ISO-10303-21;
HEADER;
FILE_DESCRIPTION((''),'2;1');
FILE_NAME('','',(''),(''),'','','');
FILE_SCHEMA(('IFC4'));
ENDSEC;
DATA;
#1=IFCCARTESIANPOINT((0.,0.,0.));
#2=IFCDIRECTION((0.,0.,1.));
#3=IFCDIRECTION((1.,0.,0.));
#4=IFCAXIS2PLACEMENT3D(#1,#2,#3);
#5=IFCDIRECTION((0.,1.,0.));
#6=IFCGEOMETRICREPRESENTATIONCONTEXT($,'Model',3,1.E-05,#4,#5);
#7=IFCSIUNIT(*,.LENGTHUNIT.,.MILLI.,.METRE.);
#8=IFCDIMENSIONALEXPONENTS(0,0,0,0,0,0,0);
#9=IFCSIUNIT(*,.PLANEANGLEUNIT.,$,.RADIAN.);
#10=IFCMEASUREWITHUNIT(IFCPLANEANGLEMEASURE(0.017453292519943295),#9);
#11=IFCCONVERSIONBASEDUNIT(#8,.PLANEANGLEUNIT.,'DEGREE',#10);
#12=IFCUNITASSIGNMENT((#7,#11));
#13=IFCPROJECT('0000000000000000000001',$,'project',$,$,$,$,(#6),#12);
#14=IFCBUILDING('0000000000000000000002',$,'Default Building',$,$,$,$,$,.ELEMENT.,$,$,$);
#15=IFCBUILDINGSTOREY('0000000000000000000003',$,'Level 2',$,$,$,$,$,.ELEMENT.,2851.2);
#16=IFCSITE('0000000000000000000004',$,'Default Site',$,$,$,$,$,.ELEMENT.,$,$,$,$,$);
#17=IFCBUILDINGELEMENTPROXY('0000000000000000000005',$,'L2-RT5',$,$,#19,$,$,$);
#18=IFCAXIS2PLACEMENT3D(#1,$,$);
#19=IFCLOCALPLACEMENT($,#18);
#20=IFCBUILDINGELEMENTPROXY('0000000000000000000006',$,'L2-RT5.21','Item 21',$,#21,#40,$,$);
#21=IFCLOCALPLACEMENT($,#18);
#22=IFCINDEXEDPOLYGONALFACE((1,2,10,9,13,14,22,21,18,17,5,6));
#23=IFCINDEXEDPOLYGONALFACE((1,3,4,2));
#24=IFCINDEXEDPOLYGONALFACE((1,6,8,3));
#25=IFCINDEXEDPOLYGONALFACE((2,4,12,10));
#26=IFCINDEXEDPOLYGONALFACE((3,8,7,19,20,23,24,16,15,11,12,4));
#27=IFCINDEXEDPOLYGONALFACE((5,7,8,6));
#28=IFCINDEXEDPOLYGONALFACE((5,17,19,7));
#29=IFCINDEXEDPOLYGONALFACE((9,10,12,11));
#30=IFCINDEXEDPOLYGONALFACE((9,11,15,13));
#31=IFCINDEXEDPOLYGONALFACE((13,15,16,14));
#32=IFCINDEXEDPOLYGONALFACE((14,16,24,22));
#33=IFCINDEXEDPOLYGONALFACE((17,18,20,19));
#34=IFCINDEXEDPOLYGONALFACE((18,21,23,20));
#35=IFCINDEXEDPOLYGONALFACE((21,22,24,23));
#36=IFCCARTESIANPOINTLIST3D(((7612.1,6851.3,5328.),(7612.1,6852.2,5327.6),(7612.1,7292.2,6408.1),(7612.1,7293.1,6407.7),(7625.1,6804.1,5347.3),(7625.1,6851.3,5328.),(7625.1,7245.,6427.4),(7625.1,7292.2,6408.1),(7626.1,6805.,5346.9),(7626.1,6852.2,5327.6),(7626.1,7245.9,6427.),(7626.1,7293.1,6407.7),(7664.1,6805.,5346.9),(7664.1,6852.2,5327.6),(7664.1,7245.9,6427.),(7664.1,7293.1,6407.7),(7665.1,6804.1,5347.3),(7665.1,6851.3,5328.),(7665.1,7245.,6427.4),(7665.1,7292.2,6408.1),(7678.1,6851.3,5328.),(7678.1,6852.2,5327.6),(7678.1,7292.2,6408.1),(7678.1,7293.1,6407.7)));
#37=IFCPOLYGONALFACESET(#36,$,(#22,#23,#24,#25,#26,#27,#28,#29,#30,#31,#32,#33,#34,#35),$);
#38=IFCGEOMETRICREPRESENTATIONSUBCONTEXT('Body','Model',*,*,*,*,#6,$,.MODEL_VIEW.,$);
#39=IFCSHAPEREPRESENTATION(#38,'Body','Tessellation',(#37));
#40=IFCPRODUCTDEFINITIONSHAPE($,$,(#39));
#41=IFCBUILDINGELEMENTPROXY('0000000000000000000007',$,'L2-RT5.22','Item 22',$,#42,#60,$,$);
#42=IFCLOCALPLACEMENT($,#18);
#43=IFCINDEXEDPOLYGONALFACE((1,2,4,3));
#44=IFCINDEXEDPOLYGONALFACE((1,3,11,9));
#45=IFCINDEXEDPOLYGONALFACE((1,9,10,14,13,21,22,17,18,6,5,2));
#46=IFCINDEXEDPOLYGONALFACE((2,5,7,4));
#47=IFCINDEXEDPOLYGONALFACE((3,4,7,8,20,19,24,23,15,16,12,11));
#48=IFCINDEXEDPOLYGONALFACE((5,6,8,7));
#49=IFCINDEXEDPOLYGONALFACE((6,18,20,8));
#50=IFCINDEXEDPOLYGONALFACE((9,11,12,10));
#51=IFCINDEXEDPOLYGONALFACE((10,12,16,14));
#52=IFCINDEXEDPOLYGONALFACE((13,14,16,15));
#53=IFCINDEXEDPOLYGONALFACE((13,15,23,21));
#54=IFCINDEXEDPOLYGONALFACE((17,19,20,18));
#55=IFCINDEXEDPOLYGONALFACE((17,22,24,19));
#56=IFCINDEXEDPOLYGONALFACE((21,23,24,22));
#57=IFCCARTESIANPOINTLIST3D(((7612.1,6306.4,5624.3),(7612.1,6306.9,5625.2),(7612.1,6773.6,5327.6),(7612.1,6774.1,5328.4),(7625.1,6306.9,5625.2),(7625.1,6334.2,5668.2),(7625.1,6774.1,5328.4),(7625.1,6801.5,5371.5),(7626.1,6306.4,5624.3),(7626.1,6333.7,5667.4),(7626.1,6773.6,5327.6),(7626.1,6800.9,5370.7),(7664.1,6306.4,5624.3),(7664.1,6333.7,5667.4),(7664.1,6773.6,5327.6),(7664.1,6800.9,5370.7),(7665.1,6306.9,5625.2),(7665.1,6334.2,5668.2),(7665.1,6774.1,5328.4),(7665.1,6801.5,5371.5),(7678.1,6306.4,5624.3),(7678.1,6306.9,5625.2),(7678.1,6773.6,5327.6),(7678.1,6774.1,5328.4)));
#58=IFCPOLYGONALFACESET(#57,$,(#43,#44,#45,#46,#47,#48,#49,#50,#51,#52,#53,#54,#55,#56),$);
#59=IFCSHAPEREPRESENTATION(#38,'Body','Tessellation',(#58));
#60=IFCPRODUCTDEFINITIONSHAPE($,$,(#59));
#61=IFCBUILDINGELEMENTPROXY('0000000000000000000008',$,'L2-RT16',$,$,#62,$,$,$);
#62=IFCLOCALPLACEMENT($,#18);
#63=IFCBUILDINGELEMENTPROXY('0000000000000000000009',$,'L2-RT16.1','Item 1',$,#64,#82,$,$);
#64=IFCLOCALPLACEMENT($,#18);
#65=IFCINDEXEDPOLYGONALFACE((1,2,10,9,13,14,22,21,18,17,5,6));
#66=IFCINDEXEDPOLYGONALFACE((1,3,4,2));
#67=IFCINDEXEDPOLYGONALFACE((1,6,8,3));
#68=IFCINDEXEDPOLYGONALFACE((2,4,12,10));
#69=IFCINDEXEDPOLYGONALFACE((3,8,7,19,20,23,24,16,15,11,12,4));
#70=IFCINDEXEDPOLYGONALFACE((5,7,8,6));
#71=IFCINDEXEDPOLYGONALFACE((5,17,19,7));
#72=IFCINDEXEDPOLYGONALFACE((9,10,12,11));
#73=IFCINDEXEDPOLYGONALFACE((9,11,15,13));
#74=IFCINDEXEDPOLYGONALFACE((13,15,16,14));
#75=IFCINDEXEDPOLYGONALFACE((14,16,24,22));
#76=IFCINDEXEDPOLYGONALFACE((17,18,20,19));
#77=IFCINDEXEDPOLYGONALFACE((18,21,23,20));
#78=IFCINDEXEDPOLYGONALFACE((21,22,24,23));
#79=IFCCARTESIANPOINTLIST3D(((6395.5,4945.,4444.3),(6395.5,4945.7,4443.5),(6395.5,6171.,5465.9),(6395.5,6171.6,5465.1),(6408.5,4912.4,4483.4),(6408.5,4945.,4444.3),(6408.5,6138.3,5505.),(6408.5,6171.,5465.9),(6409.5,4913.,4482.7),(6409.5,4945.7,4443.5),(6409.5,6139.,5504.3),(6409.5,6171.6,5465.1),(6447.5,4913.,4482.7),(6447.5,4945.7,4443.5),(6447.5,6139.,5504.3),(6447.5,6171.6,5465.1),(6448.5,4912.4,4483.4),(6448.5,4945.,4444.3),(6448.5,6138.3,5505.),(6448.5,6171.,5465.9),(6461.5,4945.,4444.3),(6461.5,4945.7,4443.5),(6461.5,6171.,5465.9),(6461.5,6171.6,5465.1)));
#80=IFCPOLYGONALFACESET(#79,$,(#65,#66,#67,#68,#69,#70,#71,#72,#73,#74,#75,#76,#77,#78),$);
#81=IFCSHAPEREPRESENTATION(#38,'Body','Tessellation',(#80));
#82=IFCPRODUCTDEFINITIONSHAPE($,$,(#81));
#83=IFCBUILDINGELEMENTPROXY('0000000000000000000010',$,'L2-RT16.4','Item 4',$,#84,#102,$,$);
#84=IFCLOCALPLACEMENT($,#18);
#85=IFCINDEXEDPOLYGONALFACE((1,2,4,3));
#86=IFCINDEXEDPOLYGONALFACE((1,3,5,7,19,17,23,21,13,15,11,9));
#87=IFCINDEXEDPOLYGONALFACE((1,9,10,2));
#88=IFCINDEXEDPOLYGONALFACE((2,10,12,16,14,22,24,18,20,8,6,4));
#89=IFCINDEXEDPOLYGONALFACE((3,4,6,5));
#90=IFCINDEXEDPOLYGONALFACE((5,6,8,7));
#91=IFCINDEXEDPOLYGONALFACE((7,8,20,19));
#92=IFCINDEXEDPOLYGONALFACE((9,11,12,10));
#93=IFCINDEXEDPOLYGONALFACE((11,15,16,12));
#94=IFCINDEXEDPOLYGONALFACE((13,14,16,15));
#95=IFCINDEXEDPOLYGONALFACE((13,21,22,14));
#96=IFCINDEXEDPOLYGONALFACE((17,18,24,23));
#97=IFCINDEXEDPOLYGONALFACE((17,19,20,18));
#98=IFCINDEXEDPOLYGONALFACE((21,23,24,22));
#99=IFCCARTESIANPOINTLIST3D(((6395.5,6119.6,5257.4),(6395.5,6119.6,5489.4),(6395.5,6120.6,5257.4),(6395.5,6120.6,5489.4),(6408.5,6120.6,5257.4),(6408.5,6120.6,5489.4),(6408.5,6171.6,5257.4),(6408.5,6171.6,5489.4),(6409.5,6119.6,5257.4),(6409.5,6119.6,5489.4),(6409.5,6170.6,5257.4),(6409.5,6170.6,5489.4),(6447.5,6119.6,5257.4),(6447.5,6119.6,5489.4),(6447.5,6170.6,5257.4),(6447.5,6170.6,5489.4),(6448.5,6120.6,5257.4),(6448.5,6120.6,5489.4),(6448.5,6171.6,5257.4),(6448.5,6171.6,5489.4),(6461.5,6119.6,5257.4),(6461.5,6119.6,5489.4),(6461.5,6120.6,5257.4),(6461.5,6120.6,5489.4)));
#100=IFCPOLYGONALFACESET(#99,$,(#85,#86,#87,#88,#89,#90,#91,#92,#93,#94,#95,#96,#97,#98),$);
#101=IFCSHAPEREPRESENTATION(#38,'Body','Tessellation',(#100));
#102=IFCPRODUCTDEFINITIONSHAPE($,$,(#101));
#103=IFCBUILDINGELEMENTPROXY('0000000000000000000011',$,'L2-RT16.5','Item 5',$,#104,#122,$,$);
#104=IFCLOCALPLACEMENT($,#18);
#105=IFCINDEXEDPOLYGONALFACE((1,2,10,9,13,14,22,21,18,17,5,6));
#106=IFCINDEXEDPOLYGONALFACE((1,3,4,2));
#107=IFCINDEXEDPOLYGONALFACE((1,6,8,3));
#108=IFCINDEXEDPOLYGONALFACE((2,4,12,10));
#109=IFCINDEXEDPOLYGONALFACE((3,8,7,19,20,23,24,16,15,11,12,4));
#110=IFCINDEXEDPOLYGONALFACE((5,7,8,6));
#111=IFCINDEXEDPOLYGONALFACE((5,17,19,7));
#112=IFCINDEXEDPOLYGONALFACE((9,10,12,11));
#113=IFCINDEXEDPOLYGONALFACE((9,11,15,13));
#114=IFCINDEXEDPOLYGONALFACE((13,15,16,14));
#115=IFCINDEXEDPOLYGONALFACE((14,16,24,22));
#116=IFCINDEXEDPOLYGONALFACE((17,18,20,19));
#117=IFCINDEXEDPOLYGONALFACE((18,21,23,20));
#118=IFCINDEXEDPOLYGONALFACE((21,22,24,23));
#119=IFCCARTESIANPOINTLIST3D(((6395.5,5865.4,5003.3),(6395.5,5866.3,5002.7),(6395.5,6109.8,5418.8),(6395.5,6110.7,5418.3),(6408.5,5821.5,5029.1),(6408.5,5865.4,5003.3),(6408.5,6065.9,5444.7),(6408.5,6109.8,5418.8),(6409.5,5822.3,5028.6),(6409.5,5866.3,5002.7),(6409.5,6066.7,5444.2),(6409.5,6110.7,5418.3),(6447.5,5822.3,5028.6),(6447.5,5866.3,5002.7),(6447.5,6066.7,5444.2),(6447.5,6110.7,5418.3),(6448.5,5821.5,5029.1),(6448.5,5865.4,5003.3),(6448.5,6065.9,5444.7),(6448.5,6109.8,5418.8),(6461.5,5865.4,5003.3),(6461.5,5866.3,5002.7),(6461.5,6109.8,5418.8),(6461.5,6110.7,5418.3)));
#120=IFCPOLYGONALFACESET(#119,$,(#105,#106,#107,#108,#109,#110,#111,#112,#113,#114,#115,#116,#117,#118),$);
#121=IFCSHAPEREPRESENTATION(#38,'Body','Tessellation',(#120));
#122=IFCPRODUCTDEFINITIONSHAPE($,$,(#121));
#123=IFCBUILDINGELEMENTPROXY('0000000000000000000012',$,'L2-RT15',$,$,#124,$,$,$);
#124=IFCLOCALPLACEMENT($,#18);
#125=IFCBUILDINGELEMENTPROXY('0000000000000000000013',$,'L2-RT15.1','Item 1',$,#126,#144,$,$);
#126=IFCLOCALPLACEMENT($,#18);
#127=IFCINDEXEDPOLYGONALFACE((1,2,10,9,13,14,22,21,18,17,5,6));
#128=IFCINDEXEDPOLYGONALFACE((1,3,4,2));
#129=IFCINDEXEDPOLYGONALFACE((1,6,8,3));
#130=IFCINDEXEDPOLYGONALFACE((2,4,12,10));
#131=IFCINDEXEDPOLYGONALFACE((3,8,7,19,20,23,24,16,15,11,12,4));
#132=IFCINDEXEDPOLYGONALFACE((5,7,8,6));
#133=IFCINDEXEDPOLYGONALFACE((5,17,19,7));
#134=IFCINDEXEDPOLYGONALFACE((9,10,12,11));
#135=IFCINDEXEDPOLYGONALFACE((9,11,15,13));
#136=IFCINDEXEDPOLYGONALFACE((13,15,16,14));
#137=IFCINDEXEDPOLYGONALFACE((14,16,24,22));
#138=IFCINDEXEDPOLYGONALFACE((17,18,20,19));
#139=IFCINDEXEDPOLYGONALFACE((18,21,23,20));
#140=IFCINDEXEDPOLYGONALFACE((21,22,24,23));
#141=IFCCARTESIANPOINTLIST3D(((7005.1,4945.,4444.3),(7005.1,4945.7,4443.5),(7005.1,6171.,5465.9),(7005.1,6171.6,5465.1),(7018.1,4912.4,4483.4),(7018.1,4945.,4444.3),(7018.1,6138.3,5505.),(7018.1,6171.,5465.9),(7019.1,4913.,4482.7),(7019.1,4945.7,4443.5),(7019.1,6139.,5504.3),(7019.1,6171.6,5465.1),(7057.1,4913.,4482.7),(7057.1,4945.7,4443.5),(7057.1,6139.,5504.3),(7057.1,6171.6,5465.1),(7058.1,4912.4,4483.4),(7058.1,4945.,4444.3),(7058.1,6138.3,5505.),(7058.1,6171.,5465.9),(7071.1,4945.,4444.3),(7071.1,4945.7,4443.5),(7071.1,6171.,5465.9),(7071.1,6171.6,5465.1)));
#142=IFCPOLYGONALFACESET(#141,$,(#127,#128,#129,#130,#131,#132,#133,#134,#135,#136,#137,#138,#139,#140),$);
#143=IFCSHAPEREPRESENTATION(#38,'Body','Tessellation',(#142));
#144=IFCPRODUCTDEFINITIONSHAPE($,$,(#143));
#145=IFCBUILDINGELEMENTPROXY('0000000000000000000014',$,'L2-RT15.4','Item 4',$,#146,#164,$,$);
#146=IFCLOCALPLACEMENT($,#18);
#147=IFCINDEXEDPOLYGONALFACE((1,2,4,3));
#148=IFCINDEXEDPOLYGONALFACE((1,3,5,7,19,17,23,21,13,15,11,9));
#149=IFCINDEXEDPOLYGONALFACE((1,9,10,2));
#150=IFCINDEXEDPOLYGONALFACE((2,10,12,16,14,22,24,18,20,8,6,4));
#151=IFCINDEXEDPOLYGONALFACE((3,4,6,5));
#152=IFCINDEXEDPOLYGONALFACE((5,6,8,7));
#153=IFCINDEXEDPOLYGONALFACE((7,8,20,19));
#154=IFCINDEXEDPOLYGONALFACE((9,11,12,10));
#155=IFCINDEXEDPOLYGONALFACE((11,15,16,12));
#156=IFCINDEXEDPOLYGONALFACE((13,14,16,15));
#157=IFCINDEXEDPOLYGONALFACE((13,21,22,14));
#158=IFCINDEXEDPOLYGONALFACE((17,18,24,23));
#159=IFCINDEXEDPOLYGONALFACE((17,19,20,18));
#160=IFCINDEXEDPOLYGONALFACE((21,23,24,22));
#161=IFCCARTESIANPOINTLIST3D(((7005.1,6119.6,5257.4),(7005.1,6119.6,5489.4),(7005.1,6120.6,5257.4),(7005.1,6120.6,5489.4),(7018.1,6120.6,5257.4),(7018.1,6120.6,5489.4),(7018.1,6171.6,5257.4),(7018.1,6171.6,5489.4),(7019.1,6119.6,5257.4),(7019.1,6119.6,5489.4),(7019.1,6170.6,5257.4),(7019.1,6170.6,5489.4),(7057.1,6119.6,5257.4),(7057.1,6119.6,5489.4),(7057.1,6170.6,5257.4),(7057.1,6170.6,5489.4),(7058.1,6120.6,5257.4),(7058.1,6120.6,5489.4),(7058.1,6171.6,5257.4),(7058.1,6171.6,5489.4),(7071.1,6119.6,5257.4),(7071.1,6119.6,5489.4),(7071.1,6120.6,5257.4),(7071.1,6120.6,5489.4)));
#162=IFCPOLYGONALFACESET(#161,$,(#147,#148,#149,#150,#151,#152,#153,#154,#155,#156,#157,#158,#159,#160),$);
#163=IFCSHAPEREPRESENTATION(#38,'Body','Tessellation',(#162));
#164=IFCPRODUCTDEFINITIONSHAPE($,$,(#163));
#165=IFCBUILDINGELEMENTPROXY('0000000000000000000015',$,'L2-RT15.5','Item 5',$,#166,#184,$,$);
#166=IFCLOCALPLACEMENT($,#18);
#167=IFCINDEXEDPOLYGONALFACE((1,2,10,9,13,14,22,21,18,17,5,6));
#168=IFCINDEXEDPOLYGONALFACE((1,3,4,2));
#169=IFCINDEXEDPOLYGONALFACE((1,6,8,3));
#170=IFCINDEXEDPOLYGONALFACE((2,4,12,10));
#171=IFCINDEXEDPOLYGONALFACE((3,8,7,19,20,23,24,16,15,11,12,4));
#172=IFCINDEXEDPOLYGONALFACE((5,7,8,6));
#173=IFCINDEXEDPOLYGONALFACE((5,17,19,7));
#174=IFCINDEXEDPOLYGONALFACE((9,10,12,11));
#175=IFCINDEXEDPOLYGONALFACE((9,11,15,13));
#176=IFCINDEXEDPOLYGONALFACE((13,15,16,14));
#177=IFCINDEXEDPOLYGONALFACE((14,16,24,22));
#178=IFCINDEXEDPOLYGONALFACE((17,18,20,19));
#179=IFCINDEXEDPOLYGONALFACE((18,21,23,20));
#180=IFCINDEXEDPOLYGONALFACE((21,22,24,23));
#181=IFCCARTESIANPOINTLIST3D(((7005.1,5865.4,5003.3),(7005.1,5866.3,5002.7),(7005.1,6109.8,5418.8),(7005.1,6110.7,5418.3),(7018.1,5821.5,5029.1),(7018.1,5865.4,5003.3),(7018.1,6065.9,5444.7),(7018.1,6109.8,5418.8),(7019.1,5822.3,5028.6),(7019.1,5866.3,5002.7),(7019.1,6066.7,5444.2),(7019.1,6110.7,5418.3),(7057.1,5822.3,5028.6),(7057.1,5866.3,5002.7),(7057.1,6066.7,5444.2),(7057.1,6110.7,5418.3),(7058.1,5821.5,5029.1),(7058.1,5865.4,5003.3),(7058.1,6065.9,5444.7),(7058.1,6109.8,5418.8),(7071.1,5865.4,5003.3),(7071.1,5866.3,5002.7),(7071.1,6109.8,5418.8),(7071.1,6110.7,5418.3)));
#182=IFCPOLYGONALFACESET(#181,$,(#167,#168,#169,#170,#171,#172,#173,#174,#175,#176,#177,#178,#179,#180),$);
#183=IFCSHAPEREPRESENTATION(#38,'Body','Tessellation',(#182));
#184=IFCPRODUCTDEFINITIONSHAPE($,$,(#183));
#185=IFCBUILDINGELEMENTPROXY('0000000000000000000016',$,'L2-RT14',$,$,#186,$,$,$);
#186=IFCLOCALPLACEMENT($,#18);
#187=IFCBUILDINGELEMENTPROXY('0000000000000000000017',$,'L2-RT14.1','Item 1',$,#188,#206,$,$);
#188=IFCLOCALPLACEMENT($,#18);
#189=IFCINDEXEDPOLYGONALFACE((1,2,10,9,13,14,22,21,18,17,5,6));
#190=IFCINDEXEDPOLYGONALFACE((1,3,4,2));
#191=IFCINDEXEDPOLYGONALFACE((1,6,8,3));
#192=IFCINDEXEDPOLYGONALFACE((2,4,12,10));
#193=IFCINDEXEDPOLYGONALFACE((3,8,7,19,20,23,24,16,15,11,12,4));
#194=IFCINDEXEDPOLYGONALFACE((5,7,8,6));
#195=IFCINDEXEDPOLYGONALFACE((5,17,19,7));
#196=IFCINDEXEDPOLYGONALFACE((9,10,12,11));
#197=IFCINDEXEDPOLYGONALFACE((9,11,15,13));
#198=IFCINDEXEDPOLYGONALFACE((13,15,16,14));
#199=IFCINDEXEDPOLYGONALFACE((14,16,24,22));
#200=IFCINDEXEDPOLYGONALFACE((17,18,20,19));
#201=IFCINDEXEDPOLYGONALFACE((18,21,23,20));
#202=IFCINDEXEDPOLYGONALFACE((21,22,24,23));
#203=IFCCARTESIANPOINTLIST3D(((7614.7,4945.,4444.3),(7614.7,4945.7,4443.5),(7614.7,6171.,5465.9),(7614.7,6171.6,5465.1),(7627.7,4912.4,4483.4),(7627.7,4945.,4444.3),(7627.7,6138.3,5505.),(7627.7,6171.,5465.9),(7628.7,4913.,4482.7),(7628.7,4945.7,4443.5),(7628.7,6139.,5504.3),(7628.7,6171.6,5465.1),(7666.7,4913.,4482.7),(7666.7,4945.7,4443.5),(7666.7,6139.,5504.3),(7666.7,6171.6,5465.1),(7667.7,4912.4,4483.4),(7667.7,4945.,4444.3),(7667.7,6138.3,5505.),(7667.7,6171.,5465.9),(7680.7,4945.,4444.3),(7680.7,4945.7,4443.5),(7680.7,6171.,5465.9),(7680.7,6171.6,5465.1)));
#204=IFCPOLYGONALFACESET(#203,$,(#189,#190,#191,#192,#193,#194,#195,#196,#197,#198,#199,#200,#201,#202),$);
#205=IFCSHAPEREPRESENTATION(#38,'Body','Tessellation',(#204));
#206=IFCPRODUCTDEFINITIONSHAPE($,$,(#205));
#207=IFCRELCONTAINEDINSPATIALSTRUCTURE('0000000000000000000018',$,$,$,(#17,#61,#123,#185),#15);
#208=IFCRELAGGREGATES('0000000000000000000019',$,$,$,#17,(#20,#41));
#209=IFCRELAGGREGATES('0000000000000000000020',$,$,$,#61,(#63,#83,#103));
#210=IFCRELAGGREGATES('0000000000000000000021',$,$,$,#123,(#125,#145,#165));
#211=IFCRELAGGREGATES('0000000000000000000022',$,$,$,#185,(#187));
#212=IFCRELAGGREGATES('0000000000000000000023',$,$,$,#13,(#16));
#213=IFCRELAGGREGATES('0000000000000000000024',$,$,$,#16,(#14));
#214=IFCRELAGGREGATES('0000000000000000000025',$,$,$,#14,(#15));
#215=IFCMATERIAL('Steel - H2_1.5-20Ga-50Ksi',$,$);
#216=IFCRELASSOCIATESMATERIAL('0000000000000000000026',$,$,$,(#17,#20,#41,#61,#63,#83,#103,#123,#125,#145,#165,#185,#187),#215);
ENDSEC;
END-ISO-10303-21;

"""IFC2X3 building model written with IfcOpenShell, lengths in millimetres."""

from ifc_helpers import new_model, entity, si_unit, converted_unit, direction, frame, origin, origin_with_axes, place, context, subcontext, project, spatial, polyline, outline, extrude, material, element, aggregate, save


model = new_model("IFC2X3")

# Units and contexts
model_context = context("Model", 3, precision=1e-05, world=origin_with_axes(), true_north=direction((0.0, 1.0, 0.0)))
body_context = subcontext(model_context, "Body", "Model", "MODEL_VIEW")
ifc_project = project(units=[si_unit("LENGTHUNIT", "METRE", prefix="MILLI"), converted_unit("PLANEANGLEUNIT", "DEGREE", entity("IfcPlaneAngleMeasure", 0.017453292519943295), si_unit("PLANEANGLEUNIT", "RADIAN"), dimensions=[0, 0, 0, 0, 0, 0, 0])], contexts=[model_context])

# Site, building, storey
site = spatial("IfcSite", under=ifc_project, Name="Default Site", CompositionType="ELEMENT")
building = spatial("IfcBuilding", under=site, Name="Default Building", CompositionType="ELEMENT")
storey = spatial("IfcBuildingStorey", under=building, Name="Level 2", CompositionType="ELEMENT", Elevation=2851.2)

# Building element proxies
ifc_material = material(Name="Steel - H2_1.5-20Ga-50Ksi")
proxy_1 = element("IfcBuildingElementProxy", 1, inside=storey, material=ifc_material, Name="L2-RT5")
proxy_2_placement = place(None, frame((7612.1, 7293.1, 6407.7), z_axis=(0.0, -0.378, -0.926), x_axis=(40.0, 0.0, 0.0)))
proxy_2 = element("IfcBuildingElementProxy", 2, at=proxy_2_placement, material=ifc_material, Name="L2-RT5.21", Description="Item 21", context=body_context, shape_type="SweptSolid", body=[
    extrude(outline(polyline([(0.0, 0.0), (14.0, 0.0), (14.0, 51.0), (52.0, 51.0), (52.0, 0.0), (66.0, 0.0), (66.0, 1.0), (53.0, 1.0), (53.0, 52.0), (13.0, 52.0), (13.0, 1.0), (0.0, 1.0), (0.0, 0.0)])), origin(), (0.0, 0.0, 1.0), 1166.6),
])
proxy_3_placement = place(None, frame((7612.1, 6773.6, 5327.6), z_axis=(0.0, -0.844, 0.536), x_axis=(40.0, 0.0, 0.0)))
proxy_3 = element("IfcBuildingElementProxy", 3, at=proxy_3_placement, material=ifc_material, Name="L2-RT5.22", Description="Item 22", context=body_context, shape_type="SweptSolid", body=[
    extrude(outline(polyline([(0.0, 0.0), (14.0, 0.0), (14.0, 51.0), (52.0, 51.0), (52.0, 0.0), (66.0, 0.0), (66.0, 1.0), (53.0, 1.0), (53.0, 52.0), (13.0, 52.0), (13.0, 1.0), (0.0, 1.0), (0.0, 0.0)])), origin(), (0.0, 0.0, 1.0), 553.5),
])
aggregate(proxy_1, [proxy_2, proxy_3])
proxy_4 = element("IfcBuildingElementProxy", 4, inside=storey, material=ifc_material, Name="L2-RT16")
proxy_5_placement = place(None, frame((6395.5, 6171.6, 5465.1), z_axis=(0.0, -0.768, -0.64), x_axis=(40.0, 0.0, 0.0)))
proxy_5 = element("IfcBuildingElementProxy", 5, at=proxy_5_placement, material=ifc_material, Name="L2-RT16.1", Description="Item 1", context=body_context, shape_type="SweptSolid", body=[
    extrude(outline(polyline([(0.0, 0.0), (14.0, 0.0), (14.0, 51.0), (52.0, 51.0), (52.0, 0.0), (66.0, 0.0), (66.0, 1.0), (53.0, 1.0), (53.0, 52.0), (13.0, 52.0), (13.0, 1.0), (0.0, 1.0), (0.0, 0.0)])), origin(), (0.0, 0.0, 1.0), 1595.8),
])
proxy_6_placement = place(None, frame((6395.5, 6119.6, 5257.4), z_axis=(0.0, 0.0, 1.0), x_axis=(40.0, 0.0, 0.0)))
proxy_6 = element("IfcBuildingElementProxy", 6, at=proxy_6_placement, material=ifc_material, Name="L2-RT16.4", Description="Item 4", context=body_context, shape_type="SweptSolid", body=[
    extrude(outline(polyline([(0.0, 0.0), (14.0, 0.0), (14.0, 51.0), (52.0, 51.0), (52.0, 0.0), (66.0, 0.0), (66.0, 1.0), (53.0, 1.0), (53.0, 52.0), (13.0, 52.0), (13.0, 1.0), (0.0, 1.0), (0.0, 0.0)])), origin(), (0.0, 0.0, 1.0), 232.0),
])
proxy_7_placement = place(None, frame((6395.5, 6110.7, 5418.3), z_axis=(0.0, -0.507, -0.862), x_axis=(40.0, 0.0, 0.0)))
proxy_7 = element("IfcBuildingElementProxy", 7, at=proxy_7_placement, material=ifc_material, Name="L2-RT16.5", Description="Item 5", context=body_context, shape_type="SweptSolid", body=[
    extrude(outline(polyline([(0.0, 0.0), (14.0, 0.0), (14.0, 51.0), (52.0, 51.0), (52.0, 0.0), (66.0, 0.0), (66.0, 1.0), (53.0, 1.0), (53.0, 52.0), (13.0, 52.0), (13.0, 1.0), (0.0, 1.0), (0.0, 0.0)])), origin(), (0.0, 0.0, 1.0), 482.1),
])
aggregate(proxy_4, [proxy_5, proxy_6, proxy_7])
proxy_8 = element("IfcBuildingElementProxy", 8, inside=storey, material=ifc_material, Name="L2-RT15")
proxy_9_placement = place(None, frame((7005.1, 6171.6, 5465.1), z_axis=(0.0, -0.768, -0.64), x_axis=(40.0, 0.0, 0.0)))
proxy_9 = element("IfcBuildingElementProxy", 9, at=proxy_9_placement, material=ifc_material, Name="L2-RT15.1", Description="Item 1", context=body_context, shape_type="SweptSolid", body=[
    extrude(outline(polyline([(0.0, 0.0), (14.0, 0.0), (14.0, 51.0), (52.0, 51.0), (52.0, 0.0), (66.0, 0.0), (66.0, 1.0), (53.0, 1.0), (53.0, 52.0), (13.0, 52.0), (13.0, 1.0), (0.0, 1.0), (0.0, 0.0)])), origin(), (0.0, 0.0, 1.0), 1595.8),
])
proxy_10_placement = place(None, frame((7005.1, 6119.6, 5257.4), z_axis=(0.0, 0.0, 1.0), x_axis=(40.0, 0.0, 0.0)))
proxy_10 = element("IfcBuildingElementProxy", 10, at=proxy_10_placement, material=ifc_material, Name="L2-RT15.4", Description="Item 4", context=body_context, shape_type="SweptSolid", body=[
    extrude(outline(polyline([(0.0, 0.0), (14.0, 0.0), (14.0, 51.0), (52.0, 51.0), (52.0, 0.0), (66.0, 0.0), (66.0, 1.0), (53.0, 1.0), (53.0, 52.0), (13.0, 52.0), (13.0, 1.0), (0.0, 1.0), (0.0, 0.0)])), origin(), (0.0, 0.0, 1.0), 232.0),
])
proxy_11_placement = place(None, frame((7005.1, 6110.7, 5418.3), z_axis=(0.0, -0.507, -0.862), x_axis=(40.0, 0.0, 0.0)))
proxy_11 = element("IfcBuildingElementProxy", 11, at=proxy_11_placement, material=ifc_material, Name="L2-RT15.5", Description="Item 5", context=body_context, shape_type="SweptSolid", body=[
    extrude(outline(polyline([(0.0, 0.0), (14.0, 0.0), (14.0, 51.0), (52.0, 51.0), (52.0, 0.0), (66.0, 0.0), (66.0, 1.0), (53.0, 1.0), (53.0, 52.0), (13.0, 52.0), (13.0, 1.0), (0.0, 1.0), (0.0, 0.0)])), origin(), (0.0, 0.0, 1.0), 482.1),
])
aggregate(proxy_8, [proxy_9, proxy_10, proxy_11])
proxy_12 = element("IfcBuildingElementProxy", 12, inside=storey, material=ifc_material, Name="L2-RT14")
proxy_13_placement = place(None, frame((7614.7, 6171.6, 5465.1), z_axis=(0.0, -0.768, -0.64), x_axis=(40.0, 0.0, 0.0)))
proxy_13 = element("IfcBuildingElementProxy", 13, at=proxy_13_placement, material=ifc_material, Name="L2-RT14.1", Description="Item 1", context=body_context, shape_type="SweptSolid", body=[
    extrude(outline(polyline([(0.0, 0.0), (14.0, 0.0), (14.0, 51.0), (52.0, 51.0), (52.0, 0.0), (66.0, 0.0), (66.0, 1.0), (53.0, 1.0), (53.0, 52.0), (13.0, 52.0), (13.0, 1.0), (0.0, 1.0), (0.0, 0.0)])), origin(), (0.0, 0.0, 1.0), 1595.8),
])
aggregate(proxy_12, [proxy_13])

save(model, "model.ifc")
